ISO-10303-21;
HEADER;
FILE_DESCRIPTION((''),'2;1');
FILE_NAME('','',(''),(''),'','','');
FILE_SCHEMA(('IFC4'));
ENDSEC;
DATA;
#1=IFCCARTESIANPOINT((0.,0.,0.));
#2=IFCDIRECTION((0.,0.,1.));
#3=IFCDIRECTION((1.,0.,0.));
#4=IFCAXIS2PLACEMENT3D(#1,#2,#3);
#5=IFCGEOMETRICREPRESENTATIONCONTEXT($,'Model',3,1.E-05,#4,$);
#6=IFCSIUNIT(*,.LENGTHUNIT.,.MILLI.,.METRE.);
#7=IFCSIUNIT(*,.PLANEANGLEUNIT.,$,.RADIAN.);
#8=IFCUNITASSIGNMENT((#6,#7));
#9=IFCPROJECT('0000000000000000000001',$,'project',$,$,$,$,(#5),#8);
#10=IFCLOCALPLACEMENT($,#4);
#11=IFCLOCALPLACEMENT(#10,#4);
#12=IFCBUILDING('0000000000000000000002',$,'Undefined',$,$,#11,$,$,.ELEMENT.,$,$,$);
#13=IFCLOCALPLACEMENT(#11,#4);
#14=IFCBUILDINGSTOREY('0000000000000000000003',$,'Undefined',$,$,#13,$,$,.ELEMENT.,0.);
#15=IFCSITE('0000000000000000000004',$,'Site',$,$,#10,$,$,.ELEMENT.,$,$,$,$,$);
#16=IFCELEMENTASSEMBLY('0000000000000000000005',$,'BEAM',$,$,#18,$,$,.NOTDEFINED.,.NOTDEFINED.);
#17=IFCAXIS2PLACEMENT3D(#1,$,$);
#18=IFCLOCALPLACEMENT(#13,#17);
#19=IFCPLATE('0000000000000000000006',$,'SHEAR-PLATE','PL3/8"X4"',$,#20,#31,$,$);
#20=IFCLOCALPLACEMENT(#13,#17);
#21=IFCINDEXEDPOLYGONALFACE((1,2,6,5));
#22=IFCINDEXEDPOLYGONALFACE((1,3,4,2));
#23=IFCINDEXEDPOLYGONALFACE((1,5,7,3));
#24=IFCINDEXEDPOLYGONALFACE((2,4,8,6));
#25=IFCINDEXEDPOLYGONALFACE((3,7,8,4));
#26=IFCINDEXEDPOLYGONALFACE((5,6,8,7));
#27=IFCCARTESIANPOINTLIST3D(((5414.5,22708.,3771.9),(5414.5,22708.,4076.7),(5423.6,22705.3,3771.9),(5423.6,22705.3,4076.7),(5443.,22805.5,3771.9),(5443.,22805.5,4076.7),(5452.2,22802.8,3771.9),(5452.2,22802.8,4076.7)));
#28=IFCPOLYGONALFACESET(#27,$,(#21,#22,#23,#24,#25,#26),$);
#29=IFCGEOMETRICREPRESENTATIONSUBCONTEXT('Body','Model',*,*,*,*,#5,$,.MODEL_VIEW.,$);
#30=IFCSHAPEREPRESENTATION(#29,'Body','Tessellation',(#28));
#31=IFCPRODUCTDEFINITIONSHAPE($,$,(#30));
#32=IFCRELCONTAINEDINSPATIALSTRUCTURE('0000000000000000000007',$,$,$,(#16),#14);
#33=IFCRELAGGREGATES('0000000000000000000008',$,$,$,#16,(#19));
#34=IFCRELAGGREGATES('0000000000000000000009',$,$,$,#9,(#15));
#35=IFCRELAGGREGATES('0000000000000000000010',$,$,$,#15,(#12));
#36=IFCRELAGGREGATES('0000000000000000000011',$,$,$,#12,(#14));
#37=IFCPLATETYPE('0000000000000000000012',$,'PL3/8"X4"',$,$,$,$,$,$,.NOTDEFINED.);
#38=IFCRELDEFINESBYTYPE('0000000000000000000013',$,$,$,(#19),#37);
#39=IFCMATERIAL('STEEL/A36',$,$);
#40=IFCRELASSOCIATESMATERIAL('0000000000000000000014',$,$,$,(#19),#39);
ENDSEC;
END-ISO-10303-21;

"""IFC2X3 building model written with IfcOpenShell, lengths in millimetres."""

from ifc_helpers import new_model, si_unit, frame, origin_with_axes, place, context, subcontext, project, spatial, polyline, outline, extrude, material, type_object, element, aggregate, save


model = new_model("IFC2X3")

# Units and contexts
model_context = context("Model", 3, precision=1e-05, world=origin_with_axes())
body_context = subcontext(model_context, "Body", "Model", "MODEL_VIEW")
ifc_project = project(units=[si_unit("LENGTHUNIT", "METRE", prefix="MILLI"), si_unit("PLANEANGLEUNIT", "RADIAN")], contexts=[model_context])

# Site, building, storey
site_placement = place(None, origin_with_axes())
site = spatial("IfcSite", under=ifc_project, at=site_placement, Name="Site", CompositionType="ELEMENT")
building_placement = place(site_placement, origin_with_axes())
building = spatial("IfcBuilding", under=site, at=building_placement, Name="Undefined", CompositionType="ELEMENT")
storey_placement = place(building_placement, origin_with_axes())
storey = spatial("IfcBuildingStorey", under=building, at=storey_placement, Name="Undefined", CompositionType="ELEMENT", Elevation=0.0)

# Element assembly, plate
ifc_material_1 = material(Name="STEEL/A36")
plate_type = type_object("IfcPlateType", Name="PL3/8\"X4\"", PredefinedType="NOTDEFINED")
assembly_1_placement = place(storey_placement, origin_with_axes())
assembly_1 = element("IfcElementAssembly", 1, at=assembly_1_placement, inside=storey, Name="BEAM", AssemblyPlace="NOTDEFINED", PredefinedType="NOTDEFINED")
plate_1_placement = place(assembly_1_placement, frame((5419.1, 22706.6, 4076.7), z_axis=(0.959824, -0.280602, 0.0), x_axis=(0.0, 0.0, -1.0)))
plate_1 = element("IfcPlate", 2, at=plate_1_placement, type_object=plate_type, material=ifc_material_1, Name="SHEAR-PLATE", Description="PL3/8\"X4\"", context=body_context, shape_type="SweptSolid", body=[
    extrude(outline(polyline([(0.0, 0.0), (304.8, 0.0), (304.8, 101.6), (0.0, 101.6), (0.0, 0.0)])), frame((0.0, 0.0, -4.8), z_axis=(0.0, 0.0, 1.0), x_axis=(1.0, 0.0, 0.0)), (0.0, 0.0, 1.0), 9.5),
])
aggregate(assembly_1, [plate_1])

save(model, "model.ifc")
